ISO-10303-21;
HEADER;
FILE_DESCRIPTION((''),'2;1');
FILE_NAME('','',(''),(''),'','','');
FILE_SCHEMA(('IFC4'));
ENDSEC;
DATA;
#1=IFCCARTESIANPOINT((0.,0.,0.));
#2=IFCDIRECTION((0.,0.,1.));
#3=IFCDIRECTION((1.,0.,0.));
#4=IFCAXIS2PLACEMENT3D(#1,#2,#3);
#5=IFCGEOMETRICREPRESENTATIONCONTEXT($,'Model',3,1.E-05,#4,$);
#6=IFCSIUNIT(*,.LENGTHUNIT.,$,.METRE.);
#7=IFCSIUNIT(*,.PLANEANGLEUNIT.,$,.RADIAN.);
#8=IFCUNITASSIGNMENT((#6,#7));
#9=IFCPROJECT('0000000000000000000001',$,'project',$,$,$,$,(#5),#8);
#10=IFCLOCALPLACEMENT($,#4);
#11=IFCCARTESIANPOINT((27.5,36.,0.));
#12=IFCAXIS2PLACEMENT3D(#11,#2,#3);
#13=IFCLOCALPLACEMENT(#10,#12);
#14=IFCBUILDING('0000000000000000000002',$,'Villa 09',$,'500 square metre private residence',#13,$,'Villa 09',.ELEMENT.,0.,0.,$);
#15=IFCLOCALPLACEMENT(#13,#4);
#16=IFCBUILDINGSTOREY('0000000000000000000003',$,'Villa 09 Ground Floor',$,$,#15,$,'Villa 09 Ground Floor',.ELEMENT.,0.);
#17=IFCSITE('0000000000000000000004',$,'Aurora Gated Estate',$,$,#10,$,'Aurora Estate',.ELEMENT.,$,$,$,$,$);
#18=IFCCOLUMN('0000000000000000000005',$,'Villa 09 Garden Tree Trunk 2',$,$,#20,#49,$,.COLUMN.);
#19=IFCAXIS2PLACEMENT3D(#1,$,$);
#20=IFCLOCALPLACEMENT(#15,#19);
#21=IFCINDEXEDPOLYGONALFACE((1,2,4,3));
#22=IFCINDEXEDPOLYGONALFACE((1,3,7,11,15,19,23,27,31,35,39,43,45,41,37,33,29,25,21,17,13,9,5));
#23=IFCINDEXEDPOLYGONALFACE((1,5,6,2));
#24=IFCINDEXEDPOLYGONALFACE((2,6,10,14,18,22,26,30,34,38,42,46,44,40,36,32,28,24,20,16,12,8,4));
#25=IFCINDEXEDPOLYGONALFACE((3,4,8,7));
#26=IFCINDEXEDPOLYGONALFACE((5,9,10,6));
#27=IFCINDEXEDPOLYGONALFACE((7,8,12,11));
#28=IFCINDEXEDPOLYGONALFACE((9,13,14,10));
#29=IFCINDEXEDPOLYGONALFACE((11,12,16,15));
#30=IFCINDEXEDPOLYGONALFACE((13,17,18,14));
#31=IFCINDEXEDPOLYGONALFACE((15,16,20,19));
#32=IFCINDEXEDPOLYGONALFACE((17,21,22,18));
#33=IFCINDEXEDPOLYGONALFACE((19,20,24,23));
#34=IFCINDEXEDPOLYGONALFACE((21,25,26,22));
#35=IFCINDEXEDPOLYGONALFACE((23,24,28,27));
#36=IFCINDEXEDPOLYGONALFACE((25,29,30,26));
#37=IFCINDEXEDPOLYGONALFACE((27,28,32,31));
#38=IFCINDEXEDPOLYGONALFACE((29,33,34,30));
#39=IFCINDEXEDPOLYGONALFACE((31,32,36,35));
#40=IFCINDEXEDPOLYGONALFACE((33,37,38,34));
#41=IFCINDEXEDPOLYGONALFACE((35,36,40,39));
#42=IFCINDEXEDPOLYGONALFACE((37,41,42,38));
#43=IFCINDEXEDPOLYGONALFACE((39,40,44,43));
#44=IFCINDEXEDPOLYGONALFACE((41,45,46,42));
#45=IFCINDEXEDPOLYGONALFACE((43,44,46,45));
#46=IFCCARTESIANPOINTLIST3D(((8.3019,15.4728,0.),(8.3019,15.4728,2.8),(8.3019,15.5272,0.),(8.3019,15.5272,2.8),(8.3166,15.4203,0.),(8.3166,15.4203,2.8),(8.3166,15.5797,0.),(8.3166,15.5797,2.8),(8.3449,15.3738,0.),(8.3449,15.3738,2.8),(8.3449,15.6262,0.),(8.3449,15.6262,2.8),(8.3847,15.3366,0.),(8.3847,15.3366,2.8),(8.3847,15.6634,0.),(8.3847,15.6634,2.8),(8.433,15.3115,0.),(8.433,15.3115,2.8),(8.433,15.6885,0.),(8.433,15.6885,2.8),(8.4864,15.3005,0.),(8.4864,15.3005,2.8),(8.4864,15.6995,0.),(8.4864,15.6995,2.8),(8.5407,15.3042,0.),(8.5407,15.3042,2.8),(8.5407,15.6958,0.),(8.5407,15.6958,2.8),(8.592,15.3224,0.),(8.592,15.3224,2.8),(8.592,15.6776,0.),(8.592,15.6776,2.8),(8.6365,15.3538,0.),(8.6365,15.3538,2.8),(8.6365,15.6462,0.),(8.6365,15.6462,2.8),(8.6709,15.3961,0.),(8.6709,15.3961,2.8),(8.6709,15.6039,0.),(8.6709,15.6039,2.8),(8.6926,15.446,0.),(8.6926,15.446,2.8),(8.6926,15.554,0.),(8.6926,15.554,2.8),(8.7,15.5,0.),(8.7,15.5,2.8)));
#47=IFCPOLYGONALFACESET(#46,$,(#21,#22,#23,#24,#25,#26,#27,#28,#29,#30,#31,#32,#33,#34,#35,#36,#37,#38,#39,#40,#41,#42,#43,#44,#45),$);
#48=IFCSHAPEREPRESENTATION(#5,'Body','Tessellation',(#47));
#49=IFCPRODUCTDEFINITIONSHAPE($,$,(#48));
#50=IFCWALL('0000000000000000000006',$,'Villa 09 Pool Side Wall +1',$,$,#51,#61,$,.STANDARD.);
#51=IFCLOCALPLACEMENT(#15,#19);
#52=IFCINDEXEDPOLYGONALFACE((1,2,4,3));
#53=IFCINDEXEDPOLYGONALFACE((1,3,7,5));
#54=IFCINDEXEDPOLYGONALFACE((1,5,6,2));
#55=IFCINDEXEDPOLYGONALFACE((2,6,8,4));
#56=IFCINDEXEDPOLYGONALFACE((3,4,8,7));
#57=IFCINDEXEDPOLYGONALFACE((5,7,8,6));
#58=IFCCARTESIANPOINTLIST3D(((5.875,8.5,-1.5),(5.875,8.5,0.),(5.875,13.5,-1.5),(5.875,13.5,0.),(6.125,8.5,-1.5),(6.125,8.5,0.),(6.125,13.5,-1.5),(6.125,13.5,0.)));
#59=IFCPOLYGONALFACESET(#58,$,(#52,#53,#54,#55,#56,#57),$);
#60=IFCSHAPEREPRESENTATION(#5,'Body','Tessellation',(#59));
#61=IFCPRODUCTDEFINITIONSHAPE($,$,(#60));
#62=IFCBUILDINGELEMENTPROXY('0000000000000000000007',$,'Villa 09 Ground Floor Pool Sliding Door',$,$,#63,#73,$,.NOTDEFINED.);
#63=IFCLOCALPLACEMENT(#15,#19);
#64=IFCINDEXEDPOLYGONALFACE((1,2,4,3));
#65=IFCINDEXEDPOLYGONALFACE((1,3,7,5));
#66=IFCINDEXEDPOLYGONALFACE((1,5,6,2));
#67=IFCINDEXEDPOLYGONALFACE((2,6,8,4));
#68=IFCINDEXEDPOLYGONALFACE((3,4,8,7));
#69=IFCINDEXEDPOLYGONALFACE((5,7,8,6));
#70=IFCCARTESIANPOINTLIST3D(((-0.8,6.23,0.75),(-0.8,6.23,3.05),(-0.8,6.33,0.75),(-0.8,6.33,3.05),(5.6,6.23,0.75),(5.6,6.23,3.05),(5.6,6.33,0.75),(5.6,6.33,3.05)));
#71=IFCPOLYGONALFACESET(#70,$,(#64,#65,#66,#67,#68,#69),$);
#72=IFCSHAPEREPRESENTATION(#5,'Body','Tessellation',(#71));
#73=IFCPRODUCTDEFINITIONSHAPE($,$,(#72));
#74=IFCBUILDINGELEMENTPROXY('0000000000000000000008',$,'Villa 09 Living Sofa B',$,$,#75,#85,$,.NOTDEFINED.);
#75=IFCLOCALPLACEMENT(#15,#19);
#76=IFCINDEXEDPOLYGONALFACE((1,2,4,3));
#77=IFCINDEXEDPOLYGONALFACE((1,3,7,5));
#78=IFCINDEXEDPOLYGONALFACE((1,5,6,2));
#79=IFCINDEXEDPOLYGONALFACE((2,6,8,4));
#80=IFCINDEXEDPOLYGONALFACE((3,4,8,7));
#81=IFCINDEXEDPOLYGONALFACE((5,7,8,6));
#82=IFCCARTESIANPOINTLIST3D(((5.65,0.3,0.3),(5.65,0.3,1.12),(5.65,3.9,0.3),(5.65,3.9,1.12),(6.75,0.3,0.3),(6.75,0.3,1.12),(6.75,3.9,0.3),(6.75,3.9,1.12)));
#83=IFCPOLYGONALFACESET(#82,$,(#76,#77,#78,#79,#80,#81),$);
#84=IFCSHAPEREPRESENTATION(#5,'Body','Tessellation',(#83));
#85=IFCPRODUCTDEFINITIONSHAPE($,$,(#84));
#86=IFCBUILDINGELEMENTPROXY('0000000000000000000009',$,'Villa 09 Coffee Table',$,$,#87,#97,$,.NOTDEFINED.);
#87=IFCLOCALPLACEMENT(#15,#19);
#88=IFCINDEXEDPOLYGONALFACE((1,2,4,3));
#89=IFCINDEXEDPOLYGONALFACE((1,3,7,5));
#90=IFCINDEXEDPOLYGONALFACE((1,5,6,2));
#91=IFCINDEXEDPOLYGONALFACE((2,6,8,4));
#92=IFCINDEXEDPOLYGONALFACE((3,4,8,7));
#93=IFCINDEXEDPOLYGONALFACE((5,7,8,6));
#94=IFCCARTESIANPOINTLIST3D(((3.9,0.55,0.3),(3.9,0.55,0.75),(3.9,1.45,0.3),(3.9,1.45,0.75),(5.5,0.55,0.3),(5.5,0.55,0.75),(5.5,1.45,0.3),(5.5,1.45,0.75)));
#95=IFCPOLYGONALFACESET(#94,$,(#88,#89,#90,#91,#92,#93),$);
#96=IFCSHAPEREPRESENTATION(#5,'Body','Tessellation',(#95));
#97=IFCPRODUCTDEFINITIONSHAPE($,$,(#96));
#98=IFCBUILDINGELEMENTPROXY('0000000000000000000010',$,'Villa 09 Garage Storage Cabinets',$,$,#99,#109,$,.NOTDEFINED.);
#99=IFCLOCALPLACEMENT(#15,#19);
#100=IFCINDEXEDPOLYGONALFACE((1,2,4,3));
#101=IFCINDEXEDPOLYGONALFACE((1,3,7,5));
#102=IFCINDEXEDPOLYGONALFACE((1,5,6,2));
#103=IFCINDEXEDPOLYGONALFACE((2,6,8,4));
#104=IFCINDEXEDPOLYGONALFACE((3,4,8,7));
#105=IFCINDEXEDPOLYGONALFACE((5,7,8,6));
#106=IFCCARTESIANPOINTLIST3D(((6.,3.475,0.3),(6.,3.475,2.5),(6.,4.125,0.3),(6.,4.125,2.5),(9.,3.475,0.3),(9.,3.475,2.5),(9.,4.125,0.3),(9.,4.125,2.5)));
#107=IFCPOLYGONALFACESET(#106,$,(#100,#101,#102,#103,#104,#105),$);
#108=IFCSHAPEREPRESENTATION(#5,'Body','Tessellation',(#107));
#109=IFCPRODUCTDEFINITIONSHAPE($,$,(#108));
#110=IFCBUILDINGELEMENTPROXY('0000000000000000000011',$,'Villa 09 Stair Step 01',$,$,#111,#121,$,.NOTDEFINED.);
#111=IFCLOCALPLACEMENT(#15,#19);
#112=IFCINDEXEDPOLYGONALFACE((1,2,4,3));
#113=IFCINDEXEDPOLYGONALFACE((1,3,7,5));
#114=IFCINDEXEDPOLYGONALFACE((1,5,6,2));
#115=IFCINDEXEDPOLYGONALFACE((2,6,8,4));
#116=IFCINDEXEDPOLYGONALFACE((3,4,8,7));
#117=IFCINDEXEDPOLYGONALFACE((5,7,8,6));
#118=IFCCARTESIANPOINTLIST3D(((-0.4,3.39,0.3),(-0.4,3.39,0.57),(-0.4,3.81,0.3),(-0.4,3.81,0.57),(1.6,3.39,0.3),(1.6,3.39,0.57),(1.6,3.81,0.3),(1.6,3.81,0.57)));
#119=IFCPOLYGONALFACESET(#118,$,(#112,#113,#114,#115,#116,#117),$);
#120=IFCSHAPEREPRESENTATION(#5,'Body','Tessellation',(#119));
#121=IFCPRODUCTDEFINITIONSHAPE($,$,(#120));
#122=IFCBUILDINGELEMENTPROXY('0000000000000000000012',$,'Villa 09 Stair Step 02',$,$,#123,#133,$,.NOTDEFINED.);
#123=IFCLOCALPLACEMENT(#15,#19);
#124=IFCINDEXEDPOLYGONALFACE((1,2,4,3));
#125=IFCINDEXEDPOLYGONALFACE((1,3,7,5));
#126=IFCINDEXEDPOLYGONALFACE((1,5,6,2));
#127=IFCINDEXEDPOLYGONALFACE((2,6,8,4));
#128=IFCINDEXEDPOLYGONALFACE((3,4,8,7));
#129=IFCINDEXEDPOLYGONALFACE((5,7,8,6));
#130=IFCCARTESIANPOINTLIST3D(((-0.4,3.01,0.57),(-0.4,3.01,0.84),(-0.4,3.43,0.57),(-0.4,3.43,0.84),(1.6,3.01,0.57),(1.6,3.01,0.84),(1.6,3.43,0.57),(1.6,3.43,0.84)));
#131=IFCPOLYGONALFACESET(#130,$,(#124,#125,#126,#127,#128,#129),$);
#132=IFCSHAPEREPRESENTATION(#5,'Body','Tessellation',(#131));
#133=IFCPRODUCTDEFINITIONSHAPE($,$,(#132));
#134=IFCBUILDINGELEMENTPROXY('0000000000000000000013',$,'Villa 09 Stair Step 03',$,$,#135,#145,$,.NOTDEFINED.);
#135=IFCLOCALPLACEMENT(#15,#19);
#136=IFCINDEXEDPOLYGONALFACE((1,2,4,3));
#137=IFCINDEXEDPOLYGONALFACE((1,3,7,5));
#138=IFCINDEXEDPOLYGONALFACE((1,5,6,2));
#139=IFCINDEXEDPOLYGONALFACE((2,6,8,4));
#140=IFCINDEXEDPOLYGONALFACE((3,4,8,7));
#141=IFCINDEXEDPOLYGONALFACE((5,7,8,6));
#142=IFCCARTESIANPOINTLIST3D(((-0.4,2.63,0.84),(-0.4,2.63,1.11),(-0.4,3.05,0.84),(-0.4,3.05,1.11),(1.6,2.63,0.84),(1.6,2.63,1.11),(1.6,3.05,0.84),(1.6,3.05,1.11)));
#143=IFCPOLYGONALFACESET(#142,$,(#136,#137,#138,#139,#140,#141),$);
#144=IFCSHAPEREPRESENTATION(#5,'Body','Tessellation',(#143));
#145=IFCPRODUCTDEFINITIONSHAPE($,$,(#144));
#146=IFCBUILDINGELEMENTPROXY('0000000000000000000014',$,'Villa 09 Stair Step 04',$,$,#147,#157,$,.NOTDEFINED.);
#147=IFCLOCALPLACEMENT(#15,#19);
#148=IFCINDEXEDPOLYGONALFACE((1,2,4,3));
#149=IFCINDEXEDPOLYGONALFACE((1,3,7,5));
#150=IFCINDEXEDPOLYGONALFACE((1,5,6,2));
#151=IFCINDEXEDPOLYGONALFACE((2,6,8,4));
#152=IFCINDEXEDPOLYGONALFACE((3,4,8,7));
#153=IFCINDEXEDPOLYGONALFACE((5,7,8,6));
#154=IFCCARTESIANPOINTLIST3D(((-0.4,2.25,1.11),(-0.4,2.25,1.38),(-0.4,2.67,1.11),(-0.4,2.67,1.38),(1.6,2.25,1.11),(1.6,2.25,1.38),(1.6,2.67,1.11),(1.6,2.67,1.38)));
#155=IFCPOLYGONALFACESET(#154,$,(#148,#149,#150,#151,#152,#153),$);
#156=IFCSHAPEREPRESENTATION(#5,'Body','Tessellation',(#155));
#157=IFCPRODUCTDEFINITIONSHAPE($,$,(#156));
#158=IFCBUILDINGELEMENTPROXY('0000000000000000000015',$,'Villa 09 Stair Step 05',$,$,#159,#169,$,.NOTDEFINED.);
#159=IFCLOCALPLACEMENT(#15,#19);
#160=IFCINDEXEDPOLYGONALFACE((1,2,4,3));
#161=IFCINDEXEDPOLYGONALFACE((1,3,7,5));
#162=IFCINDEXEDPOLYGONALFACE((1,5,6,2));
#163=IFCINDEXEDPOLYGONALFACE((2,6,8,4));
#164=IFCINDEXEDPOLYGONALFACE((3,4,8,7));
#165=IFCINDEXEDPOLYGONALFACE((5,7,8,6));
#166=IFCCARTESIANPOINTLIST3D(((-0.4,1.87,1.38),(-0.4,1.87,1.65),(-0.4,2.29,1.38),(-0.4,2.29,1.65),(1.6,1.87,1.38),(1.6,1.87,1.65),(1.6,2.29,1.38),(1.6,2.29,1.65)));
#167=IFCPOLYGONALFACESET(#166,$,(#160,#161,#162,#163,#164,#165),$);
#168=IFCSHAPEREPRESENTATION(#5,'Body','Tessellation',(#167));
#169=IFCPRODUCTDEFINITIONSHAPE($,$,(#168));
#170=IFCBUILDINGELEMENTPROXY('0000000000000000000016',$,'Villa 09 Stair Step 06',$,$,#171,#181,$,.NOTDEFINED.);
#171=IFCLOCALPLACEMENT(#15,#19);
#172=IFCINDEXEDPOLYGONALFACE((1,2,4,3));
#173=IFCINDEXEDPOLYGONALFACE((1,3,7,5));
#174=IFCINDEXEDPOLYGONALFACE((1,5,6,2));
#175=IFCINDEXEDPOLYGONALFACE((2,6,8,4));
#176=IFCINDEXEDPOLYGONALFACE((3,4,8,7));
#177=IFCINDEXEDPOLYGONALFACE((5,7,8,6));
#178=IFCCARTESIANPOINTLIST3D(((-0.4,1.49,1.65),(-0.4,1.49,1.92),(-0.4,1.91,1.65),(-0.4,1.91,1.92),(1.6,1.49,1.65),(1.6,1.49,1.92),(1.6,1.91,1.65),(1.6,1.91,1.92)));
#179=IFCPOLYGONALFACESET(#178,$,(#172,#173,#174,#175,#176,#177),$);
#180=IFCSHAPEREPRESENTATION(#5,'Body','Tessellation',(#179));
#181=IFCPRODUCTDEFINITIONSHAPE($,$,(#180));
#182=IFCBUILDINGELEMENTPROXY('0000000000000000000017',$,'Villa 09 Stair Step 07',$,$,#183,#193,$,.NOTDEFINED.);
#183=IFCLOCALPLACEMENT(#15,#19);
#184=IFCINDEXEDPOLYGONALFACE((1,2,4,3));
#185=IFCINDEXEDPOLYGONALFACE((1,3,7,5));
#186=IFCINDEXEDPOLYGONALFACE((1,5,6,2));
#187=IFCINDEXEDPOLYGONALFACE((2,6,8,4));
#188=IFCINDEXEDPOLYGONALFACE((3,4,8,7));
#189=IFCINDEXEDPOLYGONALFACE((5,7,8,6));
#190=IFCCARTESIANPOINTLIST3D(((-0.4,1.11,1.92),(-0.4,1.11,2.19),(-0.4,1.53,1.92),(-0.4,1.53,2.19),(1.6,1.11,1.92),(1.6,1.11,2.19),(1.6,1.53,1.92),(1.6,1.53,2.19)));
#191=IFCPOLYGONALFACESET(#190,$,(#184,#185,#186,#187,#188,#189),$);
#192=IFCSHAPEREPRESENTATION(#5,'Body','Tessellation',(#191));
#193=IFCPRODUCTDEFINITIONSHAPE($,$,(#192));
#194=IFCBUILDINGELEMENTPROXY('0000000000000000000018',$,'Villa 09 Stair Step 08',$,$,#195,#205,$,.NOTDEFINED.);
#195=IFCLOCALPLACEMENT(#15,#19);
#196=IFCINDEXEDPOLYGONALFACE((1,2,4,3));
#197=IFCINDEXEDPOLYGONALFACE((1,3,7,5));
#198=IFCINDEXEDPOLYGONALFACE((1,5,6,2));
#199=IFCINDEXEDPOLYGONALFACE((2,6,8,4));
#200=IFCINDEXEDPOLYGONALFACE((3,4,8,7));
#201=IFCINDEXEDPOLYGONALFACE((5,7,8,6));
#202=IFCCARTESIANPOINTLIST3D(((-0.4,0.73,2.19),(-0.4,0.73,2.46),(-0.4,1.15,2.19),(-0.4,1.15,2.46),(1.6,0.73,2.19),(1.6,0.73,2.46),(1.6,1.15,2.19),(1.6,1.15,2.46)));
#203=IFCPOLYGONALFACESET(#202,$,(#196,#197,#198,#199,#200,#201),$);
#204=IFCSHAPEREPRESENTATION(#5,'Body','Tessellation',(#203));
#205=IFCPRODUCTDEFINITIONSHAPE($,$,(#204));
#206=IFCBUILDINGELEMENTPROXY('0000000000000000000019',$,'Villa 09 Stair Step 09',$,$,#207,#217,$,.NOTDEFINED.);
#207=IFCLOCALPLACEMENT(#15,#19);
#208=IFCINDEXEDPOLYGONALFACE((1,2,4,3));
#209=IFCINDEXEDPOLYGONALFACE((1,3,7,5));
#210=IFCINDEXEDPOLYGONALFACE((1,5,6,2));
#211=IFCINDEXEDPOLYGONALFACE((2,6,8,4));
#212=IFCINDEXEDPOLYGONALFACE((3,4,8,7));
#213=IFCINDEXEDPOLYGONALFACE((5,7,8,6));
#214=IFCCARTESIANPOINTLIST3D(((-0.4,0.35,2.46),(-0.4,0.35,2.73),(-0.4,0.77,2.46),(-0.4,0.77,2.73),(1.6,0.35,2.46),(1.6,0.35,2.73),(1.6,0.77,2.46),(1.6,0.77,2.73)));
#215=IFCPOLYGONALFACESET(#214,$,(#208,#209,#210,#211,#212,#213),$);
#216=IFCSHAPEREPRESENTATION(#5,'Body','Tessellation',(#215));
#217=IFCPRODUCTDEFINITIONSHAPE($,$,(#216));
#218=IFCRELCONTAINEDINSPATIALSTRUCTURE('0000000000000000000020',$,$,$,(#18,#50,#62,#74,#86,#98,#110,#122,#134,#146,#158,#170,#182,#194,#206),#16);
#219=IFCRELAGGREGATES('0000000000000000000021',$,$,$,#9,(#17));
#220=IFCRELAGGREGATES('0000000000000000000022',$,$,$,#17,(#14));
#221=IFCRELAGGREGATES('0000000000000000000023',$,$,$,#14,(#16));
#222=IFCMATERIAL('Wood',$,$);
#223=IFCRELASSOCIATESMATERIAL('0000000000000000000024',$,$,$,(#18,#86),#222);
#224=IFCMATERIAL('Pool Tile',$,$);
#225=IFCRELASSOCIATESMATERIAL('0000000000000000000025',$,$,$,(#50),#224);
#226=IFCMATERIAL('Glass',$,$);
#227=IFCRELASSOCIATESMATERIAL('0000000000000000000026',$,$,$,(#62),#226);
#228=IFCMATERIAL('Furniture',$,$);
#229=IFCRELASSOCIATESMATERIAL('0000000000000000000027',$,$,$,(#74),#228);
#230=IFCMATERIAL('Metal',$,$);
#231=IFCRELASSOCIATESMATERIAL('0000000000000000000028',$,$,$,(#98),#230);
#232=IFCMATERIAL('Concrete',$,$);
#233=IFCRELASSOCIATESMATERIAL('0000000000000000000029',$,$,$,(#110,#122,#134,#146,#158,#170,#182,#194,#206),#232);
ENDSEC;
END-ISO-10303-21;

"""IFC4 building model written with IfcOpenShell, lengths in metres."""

from ifc_helpers import new_model, si_unit, frame, origin_with_axes, origin_2d_with_axis, place, context, project, spatial, rectangle, circle, extrude, material, element, save


model = new_model("IFC4")

# Units and contexts
model_context = context("Model", 3, precision=1e-05, world=origin_with_axes())
ifc_project = project(units=[si_unit("LENGTHUNIT", "METRE"), si_unit("PLANEANGLEUNIT", "RADIAN")], contexts=[model_context])

# Site, building, storey
site_placement = place(None, origin_with_axes())
site = spatial("IfcSite", under=ifc_project, at=site_placement, Name="Aurora Gated Estate", LongName="Aurora Estate", CompositionType="ELEMENT")
building_placement = place(site_placement, frame((27.5, 36.0, 0.0), z_axis=(0.0, 0.0, 1.0), x_axis=(1.0, 0.0, 0.0)))
building = spatial("IfcBuilding", under=site, at=building_placement, Name="Villa 09", ObjectType="500 square metre private residence", LongName="Villa 09", CompositionType="ELEMENT", ElevationOfRefHeight=0.0, ElevationOfTerrain=0.0)
storey_placement = place(building_placement, origin_with_axes())
storey = spatial("IfcBuildingStorey", under=building, at=storey_placement, Name="Villa 09 Ground Floor", LongName="Villa 09 Ground Floor", CompositionType="ELEMENT", Elevation=0.0)

# Column
ifc_material_1 = material(Name="Wood")
column_placement = place(storey_placement, frame((8.5, 15.5, 0.0), z_axis=(0.0, 0.0, 1.0), x_axis=(1.0, 0.0, 0.0)))
element("IfcColumn", 1, at=column_placement, inside=storey, material=ifc_material_1, Name="Villa 09 Garden Tree Trunk 2", PredefinedType="COLUMN", context=model_context, shape_type="SweptSolid", body=[
    extrude(circle(Radius=0.2, at=origin_2d_with_axis()), origin_with_axes(), (0.0, 0.0, 1.0), 2.8),
])

# Wall
ifc_material_2 = material(Name="Pool Tile")
wall_placement = place(storey_placement, frame((6.0, 11.0, -1.5), z_axis=(0.0, 0.0, 1.0), x_axis=(1.0, 0.0, 0.0)))
element("IfcWall", 2, at=wall_placement, inside=storey, material=ifc_material_2, Name="Villa 09 Pool Side Wall +1", PredefinedType="STANDARD", context=model_context, shape_type="SweptSolid", body=[
    extrude(rectangle(XDim=0.25, YDim=5.0, at=origin_2d_with_axis()), origin_with_axes(), (0.0, 0.0, 1.0), 1.5),
])

# Building element proxies
ifc_material_3 = material(Name="Glass")
proxy_1_placement = place(storey_placement, frame((2.4, 6.28, 0.75), z_axis=(0.0, 0.0, 1.0), x_axis=(1.0, 0.0, 0.0)))
element("IfcBuildingElementProxy", 3, at=proxy_1_placement, inside=storey, material=ifc_material_3, Name="Villa 09 Ground Floor Pool Sliding Door", PredefinedType="NOTDEFINED", context=model_context, shape_type="SweptSolid", body=[
    extrude(rectangle(XDim=6.4, YDim=0.1, at=origin_2d_with_axis()), origin_with_axes(), (0.0, 0.0, 1.0), 2.3),
])
ifc_material_4 = material(Name="Furniture")
proxy_2_placement = place(storey_placement, frame((6.2, 2.1, 0.3), z_axis=(0.0, 0.0, 1.0), x_axis=(1.0, 0.0, 0.0)))
element("IfcBuildingElementProxy", 4, at=proxy_2_placement, inside=storey, material=ifc_material_4, Name="Villa 09 Living Sofa B", PredefinedType="NOTDEFINED", context=model_context, shape_type="SweptSolid", body=[
    extrude(rectangle(XDim=1.1, YDim=3.6, at=origin_2d_with_axis()), origin_with_axes(), (0.0, 0.0, 1.0), 0.82),
])
proxy_3_placement = place(storey_placement, frame((4.7, 1.0, 0.3), z_axis=(0.0, 0.0, 1.0), x_axis=(1.0, 0.0, 0.0)))
element("IfcBuildingElementProxy", 5, at=proxy_3_placement, inside=storey, material=ifc_material_1, Name="Villa 09 Coffee Table", PredefinedType="NOTDEFINED", context=model_context, shape_type="SweptSolid", body=[
    extrude(rectangle(XDim=1.6, YDim=0.9, at=origin_2d_with_axis()), origin_with_axes(), (0.0, 0.0, 1.0), 0.45),
])
ifc_material_5 = material(Name="Metal")
proxy_4_placement = place(storey_placement, frame((7.5, 3.8, 0.3), z_axis=(0.0, 0.0, 1.0), x_axis=(1.0, 0.0, 0.0)))
element("IfcBuildingElementProxy", 6, at=proxy_4_placement, inside=storey, material=ifc_material_5, Name="Villa 09 Garage Storage Cabinets", PredefinedType="NOTDEFINED", context=model_context, shape_type="SweptSolid", body=[
    extrude(rectangle(XDim=3.0, YDim=0.65, at=origin_2d_with_axis()), origin_with_axes(), (0.0, 0.0, 1.0), 2.2),
])
ifc_material_6 = material(Name="Concrete")
for number, where, z_axis, x_axis, name in (
    (7, (0.6, 3.6, 0.3), (0.0, 0.0, 1.0), (1.0, 0.0, 0.0), "Villa 09 Stair Step 01"),
    (8, (0.6, 3.22, 0.57), (0.0, 0.0, 1.0), (1.0, 0.0, 0.0), "Villa 09 Stair Step 02"),
    (9, (0.6, 2.84, 0.84), (0.0, 0.0, 1.0), (1.0, 0.0, 0.0), "Villa 09 Stair Step 03"),
    (10, (0.6, 2.46, 1.11), (0.0, 0.0, 1.0), (1.0, 0.0, 0.0), "Villa 09 Stair Step 04"),
    (11, (0.6, 2.08, 1.38), (0.0, 0.0, 1.0), (1.0, 0.0, 0.0), "Villa 09 Stair Step 05"),
    (12, (0.6, 1.7, 1.65), (0.0, 0.0, 1.0), (1.0, 0.0, 0.0), "Villa 09 Stair Step 06"),
    (13, (0.6, 1.32, 1.92), (0.0, 0.0, 1.0), (1.0, 0.0, 0.0), "Villa 09 Stair Step 07"),
    (14, (0.6, 0.94, 2.19), (0.0, 0.0, 1.0), (1.0, 0.0, 0.0), "Villa 09 Stair Step 08"),
    (15, (0.6, 0.56, 2.46), (0.0, 0.0, 1.0), (1.0, 0.0, 0.0), "Villa 09 Stair Step 09"),
):
    element("IfcBuildingElementProxy", number, at=place(storey_placement, frame(where, z_axis=z_axis, x_axis=x_axis)), inside=storey, material=ifc_material_6, Name=name, PredefinedType="NOTDEFINED", context=model_context, shape_type="SweptSolid", body=[
        extrude(rectangle(XDim=2.0, YDim=0.42, at=origin_2d_with_axis()), origin_with_axes(), (0.0, 0.0, 1.0), 0.27),
    ])

save(model, "model.ifc")
